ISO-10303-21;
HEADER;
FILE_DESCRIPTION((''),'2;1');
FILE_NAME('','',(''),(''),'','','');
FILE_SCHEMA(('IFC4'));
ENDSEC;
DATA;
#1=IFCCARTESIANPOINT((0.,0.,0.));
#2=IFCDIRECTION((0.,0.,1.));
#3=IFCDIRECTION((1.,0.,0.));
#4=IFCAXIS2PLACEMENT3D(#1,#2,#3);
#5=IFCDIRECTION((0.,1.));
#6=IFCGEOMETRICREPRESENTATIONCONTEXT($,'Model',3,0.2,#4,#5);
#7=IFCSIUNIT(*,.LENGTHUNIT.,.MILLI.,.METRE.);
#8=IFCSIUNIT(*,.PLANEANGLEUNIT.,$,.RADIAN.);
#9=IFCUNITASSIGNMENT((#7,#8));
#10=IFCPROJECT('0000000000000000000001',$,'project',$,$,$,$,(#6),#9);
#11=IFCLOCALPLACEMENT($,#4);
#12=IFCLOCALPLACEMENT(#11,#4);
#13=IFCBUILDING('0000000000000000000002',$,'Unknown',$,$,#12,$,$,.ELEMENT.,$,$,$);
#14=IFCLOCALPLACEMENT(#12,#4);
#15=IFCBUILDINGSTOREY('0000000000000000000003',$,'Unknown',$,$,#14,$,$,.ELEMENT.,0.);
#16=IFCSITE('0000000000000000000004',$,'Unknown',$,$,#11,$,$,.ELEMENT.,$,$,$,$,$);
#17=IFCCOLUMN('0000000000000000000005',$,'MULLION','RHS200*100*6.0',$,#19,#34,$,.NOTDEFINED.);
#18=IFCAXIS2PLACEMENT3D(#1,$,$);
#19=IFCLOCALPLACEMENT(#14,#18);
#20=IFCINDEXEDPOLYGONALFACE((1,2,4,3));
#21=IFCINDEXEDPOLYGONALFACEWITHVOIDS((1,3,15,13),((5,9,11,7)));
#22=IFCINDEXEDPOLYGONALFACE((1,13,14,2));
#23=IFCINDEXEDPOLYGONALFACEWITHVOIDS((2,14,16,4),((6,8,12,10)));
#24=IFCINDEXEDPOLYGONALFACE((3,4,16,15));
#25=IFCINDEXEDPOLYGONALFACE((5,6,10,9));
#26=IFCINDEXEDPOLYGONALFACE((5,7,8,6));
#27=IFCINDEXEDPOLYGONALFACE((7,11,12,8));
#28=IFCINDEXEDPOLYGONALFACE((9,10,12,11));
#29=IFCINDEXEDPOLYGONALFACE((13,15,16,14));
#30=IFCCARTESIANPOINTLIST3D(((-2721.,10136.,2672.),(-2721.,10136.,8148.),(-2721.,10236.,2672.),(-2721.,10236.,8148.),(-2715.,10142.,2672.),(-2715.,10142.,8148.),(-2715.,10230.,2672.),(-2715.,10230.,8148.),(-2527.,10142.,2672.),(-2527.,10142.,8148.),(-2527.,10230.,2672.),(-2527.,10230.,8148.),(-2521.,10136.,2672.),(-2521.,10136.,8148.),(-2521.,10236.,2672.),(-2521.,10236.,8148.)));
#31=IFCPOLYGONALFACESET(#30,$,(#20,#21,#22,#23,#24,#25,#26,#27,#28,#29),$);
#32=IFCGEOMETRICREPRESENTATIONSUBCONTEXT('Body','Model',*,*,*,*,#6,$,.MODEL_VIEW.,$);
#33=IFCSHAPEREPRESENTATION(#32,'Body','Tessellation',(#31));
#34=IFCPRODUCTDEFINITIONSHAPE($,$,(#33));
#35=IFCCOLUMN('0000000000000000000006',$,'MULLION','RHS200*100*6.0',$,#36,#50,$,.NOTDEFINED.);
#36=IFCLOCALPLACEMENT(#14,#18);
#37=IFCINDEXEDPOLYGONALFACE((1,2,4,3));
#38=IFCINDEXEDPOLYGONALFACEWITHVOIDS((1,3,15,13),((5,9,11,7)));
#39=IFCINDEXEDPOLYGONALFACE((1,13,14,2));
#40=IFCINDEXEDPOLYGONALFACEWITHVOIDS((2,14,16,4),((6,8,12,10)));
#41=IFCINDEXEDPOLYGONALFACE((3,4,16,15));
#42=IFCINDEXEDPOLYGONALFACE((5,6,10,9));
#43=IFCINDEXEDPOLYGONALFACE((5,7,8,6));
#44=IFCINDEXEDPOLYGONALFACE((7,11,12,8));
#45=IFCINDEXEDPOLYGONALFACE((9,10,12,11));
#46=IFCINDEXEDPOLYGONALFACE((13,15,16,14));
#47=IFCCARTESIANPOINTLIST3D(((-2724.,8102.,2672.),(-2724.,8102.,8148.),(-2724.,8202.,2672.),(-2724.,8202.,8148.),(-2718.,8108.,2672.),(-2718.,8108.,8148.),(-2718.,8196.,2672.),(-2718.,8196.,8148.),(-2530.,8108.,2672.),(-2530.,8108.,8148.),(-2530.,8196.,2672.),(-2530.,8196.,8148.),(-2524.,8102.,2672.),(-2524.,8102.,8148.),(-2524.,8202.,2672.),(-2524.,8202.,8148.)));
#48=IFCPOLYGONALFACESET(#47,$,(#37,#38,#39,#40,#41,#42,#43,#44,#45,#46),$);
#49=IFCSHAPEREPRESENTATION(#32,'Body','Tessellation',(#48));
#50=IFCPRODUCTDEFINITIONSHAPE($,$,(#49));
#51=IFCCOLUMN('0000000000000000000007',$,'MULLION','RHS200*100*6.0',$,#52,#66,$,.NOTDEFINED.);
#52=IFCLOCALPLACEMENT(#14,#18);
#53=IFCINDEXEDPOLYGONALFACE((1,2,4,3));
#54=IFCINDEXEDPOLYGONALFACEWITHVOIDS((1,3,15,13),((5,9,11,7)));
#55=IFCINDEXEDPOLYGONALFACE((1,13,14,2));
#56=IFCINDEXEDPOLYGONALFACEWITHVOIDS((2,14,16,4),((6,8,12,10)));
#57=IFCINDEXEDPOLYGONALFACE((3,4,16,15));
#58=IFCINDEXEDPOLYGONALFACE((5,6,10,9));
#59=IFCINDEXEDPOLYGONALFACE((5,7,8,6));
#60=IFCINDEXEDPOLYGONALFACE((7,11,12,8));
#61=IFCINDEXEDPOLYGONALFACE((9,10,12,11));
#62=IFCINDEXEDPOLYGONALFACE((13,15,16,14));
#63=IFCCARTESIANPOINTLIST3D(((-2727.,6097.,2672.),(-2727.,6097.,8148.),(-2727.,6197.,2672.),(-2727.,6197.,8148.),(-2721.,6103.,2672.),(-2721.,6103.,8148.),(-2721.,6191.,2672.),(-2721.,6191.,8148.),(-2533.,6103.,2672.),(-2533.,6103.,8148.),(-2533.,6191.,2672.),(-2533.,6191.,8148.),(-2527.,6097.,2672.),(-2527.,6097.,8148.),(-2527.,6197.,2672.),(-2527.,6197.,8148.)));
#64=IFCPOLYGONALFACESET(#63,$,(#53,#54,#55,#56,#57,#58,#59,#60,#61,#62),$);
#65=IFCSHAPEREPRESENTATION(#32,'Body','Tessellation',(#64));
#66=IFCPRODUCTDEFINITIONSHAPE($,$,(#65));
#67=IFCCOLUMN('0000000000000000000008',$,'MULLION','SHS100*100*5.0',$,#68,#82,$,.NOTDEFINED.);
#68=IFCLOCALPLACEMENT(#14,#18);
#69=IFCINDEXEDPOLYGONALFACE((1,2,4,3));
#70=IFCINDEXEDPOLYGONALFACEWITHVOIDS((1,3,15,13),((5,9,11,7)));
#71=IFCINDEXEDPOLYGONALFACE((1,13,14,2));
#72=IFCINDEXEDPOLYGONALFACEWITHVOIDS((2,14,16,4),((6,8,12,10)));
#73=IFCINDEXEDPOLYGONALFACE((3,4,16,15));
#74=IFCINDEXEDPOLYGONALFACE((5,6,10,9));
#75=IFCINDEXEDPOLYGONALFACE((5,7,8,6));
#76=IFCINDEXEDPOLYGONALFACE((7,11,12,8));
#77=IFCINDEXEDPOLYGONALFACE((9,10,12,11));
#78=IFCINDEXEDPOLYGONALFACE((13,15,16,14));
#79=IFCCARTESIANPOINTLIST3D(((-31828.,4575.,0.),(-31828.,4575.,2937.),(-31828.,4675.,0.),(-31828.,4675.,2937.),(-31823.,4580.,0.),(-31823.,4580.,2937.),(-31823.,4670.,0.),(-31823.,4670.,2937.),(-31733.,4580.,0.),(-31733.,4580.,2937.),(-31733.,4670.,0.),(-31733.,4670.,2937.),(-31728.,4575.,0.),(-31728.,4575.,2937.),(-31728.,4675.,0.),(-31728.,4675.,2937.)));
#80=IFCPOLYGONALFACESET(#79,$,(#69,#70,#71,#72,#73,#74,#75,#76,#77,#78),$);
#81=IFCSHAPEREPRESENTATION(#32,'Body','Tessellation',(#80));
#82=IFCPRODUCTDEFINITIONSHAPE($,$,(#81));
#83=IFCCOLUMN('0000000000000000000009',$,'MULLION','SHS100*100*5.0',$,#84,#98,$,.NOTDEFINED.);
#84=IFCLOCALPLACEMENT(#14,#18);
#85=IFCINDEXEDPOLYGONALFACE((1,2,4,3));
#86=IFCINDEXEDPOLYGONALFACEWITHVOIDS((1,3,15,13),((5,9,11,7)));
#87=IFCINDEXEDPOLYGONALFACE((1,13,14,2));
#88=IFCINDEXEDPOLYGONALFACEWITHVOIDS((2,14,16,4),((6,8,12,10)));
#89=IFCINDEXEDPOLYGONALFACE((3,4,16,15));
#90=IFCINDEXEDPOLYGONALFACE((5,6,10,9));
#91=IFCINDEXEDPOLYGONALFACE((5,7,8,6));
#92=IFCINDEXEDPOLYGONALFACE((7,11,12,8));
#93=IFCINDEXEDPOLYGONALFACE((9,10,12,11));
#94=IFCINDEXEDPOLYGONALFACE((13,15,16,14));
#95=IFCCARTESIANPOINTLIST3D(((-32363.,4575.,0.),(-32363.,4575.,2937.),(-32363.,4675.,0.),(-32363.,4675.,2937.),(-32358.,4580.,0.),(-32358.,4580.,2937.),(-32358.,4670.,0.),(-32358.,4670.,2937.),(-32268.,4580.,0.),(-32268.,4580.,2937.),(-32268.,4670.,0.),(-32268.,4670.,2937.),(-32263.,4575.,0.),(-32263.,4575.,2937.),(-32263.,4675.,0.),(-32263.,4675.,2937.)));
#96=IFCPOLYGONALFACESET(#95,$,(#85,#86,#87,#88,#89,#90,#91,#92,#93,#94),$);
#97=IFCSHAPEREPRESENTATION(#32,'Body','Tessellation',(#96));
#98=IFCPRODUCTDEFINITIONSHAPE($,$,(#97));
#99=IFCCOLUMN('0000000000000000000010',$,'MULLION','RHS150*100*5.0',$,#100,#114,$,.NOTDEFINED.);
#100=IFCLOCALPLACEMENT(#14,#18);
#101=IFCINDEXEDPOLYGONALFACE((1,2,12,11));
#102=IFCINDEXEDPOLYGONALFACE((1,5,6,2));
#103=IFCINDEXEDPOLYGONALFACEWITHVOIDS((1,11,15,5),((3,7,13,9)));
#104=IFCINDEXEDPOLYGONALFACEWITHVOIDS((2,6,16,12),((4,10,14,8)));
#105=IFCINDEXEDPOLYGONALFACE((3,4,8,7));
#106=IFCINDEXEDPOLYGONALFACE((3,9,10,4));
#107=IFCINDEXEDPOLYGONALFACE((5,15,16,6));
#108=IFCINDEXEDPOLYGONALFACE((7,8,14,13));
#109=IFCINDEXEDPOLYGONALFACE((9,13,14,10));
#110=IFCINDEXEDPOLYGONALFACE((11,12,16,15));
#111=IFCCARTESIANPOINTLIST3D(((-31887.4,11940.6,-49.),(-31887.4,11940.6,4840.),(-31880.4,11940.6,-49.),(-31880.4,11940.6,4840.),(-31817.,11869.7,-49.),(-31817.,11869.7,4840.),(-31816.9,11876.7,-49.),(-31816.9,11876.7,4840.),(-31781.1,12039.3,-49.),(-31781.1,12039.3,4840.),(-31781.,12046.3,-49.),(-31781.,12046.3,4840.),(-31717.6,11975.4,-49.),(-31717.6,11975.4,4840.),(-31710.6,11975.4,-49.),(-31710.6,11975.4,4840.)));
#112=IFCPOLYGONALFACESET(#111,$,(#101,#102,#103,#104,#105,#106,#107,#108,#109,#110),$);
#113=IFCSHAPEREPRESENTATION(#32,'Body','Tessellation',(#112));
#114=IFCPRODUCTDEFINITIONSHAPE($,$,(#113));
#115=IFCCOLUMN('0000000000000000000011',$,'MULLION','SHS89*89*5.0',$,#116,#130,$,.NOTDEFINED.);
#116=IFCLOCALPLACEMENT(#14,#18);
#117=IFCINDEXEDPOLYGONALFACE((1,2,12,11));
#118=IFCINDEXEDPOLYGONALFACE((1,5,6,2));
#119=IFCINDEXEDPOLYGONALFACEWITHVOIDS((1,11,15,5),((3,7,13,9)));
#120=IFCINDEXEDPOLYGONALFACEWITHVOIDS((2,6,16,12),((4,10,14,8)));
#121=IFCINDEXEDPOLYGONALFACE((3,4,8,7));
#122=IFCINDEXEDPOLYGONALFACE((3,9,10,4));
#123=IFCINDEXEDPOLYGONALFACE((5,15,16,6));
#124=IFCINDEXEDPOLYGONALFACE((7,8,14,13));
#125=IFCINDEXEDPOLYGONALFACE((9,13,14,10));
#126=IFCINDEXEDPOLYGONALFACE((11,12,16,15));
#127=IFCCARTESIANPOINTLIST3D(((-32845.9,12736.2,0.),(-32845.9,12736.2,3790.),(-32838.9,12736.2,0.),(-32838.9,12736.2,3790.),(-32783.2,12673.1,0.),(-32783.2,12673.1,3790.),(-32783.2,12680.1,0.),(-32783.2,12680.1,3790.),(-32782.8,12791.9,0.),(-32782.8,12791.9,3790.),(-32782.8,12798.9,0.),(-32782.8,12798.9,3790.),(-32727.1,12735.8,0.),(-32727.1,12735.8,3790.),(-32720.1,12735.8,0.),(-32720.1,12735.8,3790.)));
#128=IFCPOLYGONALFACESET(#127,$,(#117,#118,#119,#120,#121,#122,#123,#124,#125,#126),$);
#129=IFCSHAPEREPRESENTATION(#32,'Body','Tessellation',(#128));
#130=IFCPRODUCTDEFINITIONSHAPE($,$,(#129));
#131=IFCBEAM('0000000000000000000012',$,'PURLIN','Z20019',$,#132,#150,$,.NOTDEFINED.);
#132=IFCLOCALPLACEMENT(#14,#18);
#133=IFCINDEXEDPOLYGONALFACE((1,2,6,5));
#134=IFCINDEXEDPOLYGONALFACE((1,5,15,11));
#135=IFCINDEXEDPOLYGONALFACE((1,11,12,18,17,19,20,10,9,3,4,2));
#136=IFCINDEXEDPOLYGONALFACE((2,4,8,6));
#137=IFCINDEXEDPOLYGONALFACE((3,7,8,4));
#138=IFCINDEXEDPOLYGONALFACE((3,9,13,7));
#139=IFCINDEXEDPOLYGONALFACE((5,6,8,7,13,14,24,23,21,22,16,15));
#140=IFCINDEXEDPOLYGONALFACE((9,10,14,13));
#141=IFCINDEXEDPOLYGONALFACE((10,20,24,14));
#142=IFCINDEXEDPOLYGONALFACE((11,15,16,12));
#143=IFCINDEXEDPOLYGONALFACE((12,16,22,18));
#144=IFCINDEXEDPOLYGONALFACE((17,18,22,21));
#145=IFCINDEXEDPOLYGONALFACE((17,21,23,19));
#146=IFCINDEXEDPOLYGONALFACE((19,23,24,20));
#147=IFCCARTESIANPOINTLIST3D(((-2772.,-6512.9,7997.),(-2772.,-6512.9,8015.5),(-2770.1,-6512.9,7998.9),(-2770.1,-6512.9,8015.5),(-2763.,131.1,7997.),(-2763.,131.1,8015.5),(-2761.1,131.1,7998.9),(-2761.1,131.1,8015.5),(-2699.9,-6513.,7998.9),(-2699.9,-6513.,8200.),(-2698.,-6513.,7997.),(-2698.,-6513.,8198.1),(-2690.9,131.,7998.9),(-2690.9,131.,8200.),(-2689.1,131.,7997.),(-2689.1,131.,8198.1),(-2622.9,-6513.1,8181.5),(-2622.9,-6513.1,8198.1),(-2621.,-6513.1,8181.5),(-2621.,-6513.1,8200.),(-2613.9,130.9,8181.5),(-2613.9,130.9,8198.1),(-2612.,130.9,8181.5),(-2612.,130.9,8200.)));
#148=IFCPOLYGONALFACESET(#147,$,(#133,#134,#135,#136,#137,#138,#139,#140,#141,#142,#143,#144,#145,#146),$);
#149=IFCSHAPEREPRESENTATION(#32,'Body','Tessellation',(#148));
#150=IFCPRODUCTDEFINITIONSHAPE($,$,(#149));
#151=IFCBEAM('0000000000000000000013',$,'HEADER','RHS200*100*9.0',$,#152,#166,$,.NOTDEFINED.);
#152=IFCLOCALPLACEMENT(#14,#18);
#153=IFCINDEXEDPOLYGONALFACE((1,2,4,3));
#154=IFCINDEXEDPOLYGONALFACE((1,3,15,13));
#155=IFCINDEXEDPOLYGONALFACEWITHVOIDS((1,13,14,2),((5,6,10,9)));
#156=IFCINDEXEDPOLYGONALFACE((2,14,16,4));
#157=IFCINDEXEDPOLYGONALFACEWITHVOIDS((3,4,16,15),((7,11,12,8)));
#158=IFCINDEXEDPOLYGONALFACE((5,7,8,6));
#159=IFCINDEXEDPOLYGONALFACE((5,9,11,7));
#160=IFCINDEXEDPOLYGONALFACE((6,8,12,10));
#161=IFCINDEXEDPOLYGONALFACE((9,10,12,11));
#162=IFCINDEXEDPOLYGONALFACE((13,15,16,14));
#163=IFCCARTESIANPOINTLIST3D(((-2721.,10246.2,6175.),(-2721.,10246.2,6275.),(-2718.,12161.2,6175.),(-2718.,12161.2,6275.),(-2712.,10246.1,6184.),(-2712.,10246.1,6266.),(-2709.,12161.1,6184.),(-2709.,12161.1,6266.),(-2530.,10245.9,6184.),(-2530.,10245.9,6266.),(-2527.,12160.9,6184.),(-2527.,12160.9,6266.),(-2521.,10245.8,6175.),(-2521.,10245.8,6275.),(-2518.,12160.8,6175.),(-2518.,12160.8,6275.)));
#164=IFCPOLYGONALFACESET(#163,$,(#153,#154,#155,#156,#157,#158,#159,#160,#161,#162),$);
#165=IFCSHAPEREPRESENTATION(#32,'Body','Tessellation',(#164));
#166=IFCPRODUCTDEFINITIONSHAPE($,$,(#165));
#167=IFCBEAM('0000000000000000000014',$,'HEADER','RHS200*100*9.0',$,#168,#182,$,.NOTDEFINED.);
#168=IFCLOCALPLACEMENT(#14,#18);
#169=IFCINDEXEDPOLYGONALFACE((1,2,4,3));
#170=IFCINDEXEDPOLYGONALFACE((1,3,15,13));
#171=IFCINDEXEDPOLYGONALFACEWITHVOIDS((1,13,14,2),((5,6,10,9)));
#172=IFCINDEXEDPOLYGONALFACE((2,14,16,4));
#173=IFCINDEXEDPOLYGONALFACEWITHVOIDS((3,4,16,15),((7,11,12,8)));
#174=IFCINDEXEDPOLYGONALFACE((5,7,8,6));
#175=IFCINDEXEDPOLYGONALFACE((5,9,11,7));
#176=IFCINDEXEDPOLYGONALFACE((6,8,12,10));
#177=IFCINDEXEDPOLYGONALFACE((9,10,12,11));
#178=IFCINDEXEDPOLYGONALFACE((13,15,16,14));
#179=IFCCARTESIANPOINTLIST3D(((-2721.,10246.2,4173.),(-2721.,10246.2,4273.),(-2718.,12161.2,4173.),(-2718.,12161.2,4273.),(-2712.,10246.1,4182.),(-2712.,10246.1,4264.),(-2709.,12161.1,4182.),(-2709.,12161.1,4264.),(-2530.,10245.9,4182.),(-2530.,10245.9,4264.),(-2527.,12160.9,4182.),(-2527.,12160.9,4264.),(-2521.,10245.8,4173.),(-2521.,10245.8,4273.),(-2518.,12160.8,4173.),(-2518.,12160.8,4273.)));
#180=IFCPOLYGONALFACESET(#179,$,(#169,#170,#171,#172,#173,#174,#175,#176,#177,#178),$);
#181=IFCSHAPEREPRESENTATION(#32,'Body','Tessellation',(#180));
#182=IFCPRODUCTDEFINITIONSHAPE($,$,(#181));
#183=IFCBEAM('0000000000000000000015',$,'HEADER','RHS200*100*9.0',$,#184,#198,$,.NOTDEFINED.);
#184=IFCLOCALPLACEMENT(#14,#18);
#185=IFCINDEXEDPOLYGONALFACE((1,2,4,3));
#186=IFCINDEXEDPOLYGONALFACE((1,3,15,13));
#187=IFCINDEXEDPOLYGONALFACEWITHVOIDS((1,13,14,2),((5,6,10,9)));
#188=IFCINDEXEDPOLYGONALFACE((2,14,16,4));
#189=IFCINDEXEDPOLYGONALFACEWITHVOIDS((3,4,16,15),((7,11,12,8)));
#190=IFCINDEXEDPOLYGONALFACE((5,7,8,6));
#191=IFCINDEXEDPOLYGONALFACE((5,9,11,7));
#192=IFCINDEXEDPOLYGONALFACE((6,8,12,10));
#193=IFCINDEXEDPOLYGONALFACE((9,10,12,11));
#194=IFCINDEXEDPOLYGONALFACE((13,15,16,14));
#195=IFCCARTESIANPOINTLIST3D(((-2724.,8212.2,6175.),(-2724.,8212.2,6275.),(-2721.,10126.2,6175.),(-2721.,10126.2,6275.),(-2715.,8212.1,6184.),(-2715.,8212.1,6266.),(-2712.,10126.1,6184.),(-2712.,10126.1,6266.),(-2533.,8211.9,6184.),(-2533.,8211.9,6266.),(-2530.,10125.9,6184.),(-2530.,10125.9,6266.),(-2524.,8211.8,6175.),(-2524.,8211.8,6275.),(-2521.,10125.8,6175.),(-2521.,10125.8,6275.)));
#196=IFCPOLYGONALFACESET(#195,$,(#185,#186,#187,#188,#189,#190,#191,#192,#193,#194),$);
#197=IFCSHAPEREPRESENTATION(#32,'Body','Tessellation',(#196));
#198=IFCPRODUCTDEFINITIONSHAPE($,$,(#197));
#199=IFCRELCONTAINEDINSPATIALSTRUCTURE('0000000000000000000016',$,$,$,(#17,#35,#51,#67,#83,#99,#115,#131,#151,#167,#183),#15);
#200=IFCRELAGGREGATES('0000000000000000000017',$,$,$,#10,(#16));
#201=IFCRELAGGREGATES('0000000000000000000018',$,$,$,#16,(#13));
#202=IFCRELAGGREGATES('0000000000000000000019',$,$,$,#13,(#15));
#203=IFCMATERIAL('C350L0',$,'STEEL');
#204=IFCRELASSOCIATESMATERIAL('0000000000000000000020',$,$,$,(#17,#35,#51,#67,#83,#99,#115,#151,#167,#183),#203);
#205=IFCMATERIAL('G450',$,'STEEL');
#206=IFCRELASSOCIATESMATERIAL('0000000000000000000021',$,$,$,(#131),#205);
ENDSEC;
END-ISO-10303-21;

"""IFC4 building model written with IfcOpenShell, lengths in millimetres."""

from ifc_helpers import new_model, si_unit, direction, frame, origin_with_axes, place, context, subcontext, project, spatial, line, indexed_curve, outline, extrude, material, element, save


model = new_model("IFC4")

# Units and contexts
model_context = context("Model", 3, precision=0.2, world=origin_with_axes(), true_north=direction((0.0, 1.0)))
body_context = subcontext(model_context, "Body", "Model", "MODEL_VIEW")
ifc_project = project(units=[si_unit("LENGTHUNIT", "METRE", prefix="MILLI"), si_unit("PLANEANGLEUNIT", "RADIAN")], contexts=[model_context])

# Site, building, storey
site_placement = place(None, origin_with_axes())
site = spatial("IfcSite", under=ifc_project, at=site_placement, Name="Unknown", CompositionType="ELEMENT")
building_placement = place(site_placement, origin_with_axes())
building = spatial("IfcBuilding", under=site, at=building_placement, Name="Unknown", CompositionType="ELEMENT")
storey_placement = place(building_placement, origin_with_axes())
storey = spatial("IfcBuildingStorey", under=building, at=storey_placement, Name="Unknown", CompositionType="ELEMENT", Elevation=0.0)

# Columns
ifc_material_1 = material(Name="C350L0", Category="STEEL")
for number, where, z_axis, x_axis, name in (
    (1, (-2621.0, 10186.0, 2672.0), (0.000017, -1.0, 0.0), (0.0, 0.0, 1.0), "MULLION"),
    (2, (-2624.0, 8152.0, 2672.0), (0.000017, -1.0, 0.0), (0.0, 0.0, 1.0), "MULLION"),
    (3, (-2627.0, 6147.0, 2672.0), (0.000017, -1.0, 0.0), (0.0, 0.0, 1.0), "MULLION"),
):
    element("IfcColumn", number, at=place(storey_placement, frame(where, z_axis=z_axis, x_axis=x_axis)), inside=storey, material=ifc_material_1, Name=name, Description="RHS200*100*6.0", PredefinedType="NOTDEFINED", context=body_context, shape_type="SolidModel", body=[
        extrude(outline(indexed_curve([(-50.0, -100.0), (50.0, -100.0), (50.0, 100.0), (-50.0, 100.0)], segments=[line(1, 2, 3, 4, 1)]), holes=[indexed_curve([(-44.0, -94.0), (-44.0, 94.0), (44.0, 94.0), (44.0, -94.0)], segments=[line(1, 2, 3, 4, 1)])]), frame((0.0, 0.0, 0.0), z_axis=(-1.0, 0.0, 0.0), x_axis=(0.0, 0.0, 1.0)), (0.0, 0.0, -1.0), 5476.0),
    ])
for number, where, z_axis, x_axis, name in (
    (4, (-31778.0, 4625.0, 0.0), (0.000017, -1.0, 0.0), (0.0, 0.0, 1.0), "MULLION"),
    (5, (-32313.0, 4625.0, 0.0), (0.000017, -1.0, 0.0), (0.0, 0.0, 1.0), "MULLION"),
):
    element("IfcColumn", number, at=place(storey_placement, frame(where, z_axis=z_axis, x_axis=x_axis)), inside=storey, material=ifc_material_1, Name=name, Description="SHS100*100*5.0", PredefinedType="NOTDEFINED", context=body_context, shape_type="SolidModel", body=[
        extrude(outline(indexed_curve([(-50.0, -50.0), (50.0, -50.0), (50.0, 50.0), (-50.0, 50.0)], segments=[line(1, 2, 3, 4, 1)]), holes=[indexed_curve([(-45.0, -45.0), (-45.0, 45.0), (45.0, 45.0), (45.0, -45.0)], segments=[line(1, 2, 3, 4, 1)])]), frame((0.0, 0.0, 0.0), z_axis=(-1.0, 0.0, 0.0), x_axis=(0.0, 0.0, 1.0)), (0.0, 0.0, -1.0), 2937.0),
    ])
column_1_placement = place(storey_placement, frame((-31799.0, 11958.0, -49.0), z_axis=(0.704882, -0.709325, 0.0), x_axis=(0.0, 0.0, 1.0)))
element("IfcColumn", 6, at=column_1_placement, inside=storey, material=ifc_material_1, Name="MULLION", Description="RHS150*100*5.0", PredefinedType="NOTDEFINED", context=body_context, shape_type="SolidModel", body=[
    extrude(outline(indexed_curve([(-50.0, -75.0), (50.0, -75.0), (50.0, 75.0), (-50.0, 75.0)], segments=[line(1, 2, 3, 4, 1)]), holes=[indexed_curve([(-45.0, -70.0), (-45.0, 70.0), (45.0, 70.0), (45.0, -70.0)], segments=[line(1, 2, 3, 4, 1)])]), frame((0.0, 0.0, 0.0), z_axis=(-1.0, 0.0, 0.0), x_axis=(0.0, 0.0, 1.0)), (0.0, 0.0, -1.0), 4889.0),
])
column_2_placement = place(storey_placement, frame((-32783.0, 12736.0, 0.0), z_axis=(0.709325, 0.704882, 0.0), x_axis=(0.0, 0.0, 1.0)))
element("IfcColumn", 7, at=column_2_placement, inside=storey, material=ifc_material_1, Name="MULLION", Description="SHS89*89*5.0", PredefinedType="NOTDEFINED", context=body_context, shape_type="SolidModel", body=[
    extrude(outline(indexed_curve([(-44.5, -44.5), (44.5, -44.5), (44.5, 44.5), (-44.5, 44.5)], segments=[line(1, 2, 3, 4, 1)]), holes=[indexed_curve([(-39.5, -39.5), (-39.5, 39.5), (39.5, 39.5), (39.5, -39.5)], segments=[line(1, 2, 3, 4, 1)])]), frame((0.0, 0.0, 0.0), z_axis=(-1.0, 0.0, 0.0), x_axis=(0.0, 0.0, 1.0)), (0.0, 0.0, -1.0), 3790.0),
])

# Beams
ifc_material_2 = material(Name="G450", Category="STEEL")
beam_1_placement = place(storey_placement, frame((-2690.0, 131.0, 8098.5), z_axis=(-0.999999, 0.001355, 0.0), x_axis=(-0.001355, -0.999999, 0.0)))
element("IfcBeam", 8, at=beam_1_placement, inside=storey, material=ifc_material_2, Name="PURLIN", Description="Z20019", PredefinedType="NOTDEFINED", context=body_context, shape_type="SolidModel", body=[
    extrude(outline(indexed_curve([(73.0, -101.5), (73.0, -83.0), (71.2, -83.0), (71.2, -99.6), (0.9, -99.6), (0.9, 101.5), (-78.0, 101.5), (-78.0, 83.0), (-76.2, 83.0), (-76.2, 99.6), (-0.9, 99.6), (-0.9, -101.5)], segments=[line(1, 2, 3, 4, 5, 6, 7, 8, 9, 10, 11, 12, 1)])), frame((0.0, 0.0, 0.0), z_axis=(-1.0, 0.0, 0.0), x_axis=(0.0, 0.0, 1.0)), (0.0, 0.0, -1.0), 6644.0),
])
for number, where, z_axis, x_axis, name in (
    (9, (-2621.0, 10246.0, 6225.0), (0.0, 0.0, 1.0), (0.001567, 0.999999, 0.0), "HEADER"),
    (10, (-2621.0, 10246.0, 4223.0), (0.0, 0.0, 1.0), (0.001567, 0.999999, 0.0), "HEADER"),
):
    element("IfcBeam", number, at=place(storey_placement, frame(where, z_axis=z_axis, x_axis=x_axis)), inside=storey, material=ifc_material_1, Name=name, Description="RHS200*100*9.0", PredefinedType="NOTDEFINED", context=body_context, shape_type="SolidModel", body=[
        extrude(outline(indexed_curve([(-50.0, -100.0), (50.0, -100.0), (50.0, 100.0), (-50.0, 100.0)], segments=[line(1, 2, 3, 4, 1)]), holes=[indexed_curve([(-41.0, -91.0), (-41.0, 91.0), (41.0, 91.0), (41.0, -91.0)], segments=[line(1, 2, 3, 4, 1)])]), frame((0.0, 0.0, 0.0), z_axis=(-1.0, 0.0, 0.0), x_axis=(0.0, 0.0, 1.0)), (0.0, 0.0, -1.0), 1915.0),
    ])
for number, where, z_axis, x_axis, name in (
    (11, (-2624.0, 8212.0, 6225.0), (0.0, 0.0, 1.0), (0.001567, 0.999999, 0.0), "HEADER"),
):
    element("IfcBeam", number, at=place(storey_placement, frame(where, z_axis=z_axis, x_axis=x_axis)), inside=storey, material=ifc_material_1, Name=name, Description="RHS200*100*9.0", PredefinedType="NOTDEFINED", context=body_context, shape_type="SolidModel", body=[
        extrude(outline(indexed_curve([(-50.0, -100.0), (50.0, -100.0), (50.0, 100.0), (-50.0, 100.0)], segments=[line(1, 2, 3, 4, 1)]), holes=[indexed_curve([(-41.0, -91.0), (-41.0, 91.0), (41.0, 91.0), (41.0, -91.0)], segments=[line(1, 2, 3, 4, 1)])]), frame((0.0, 0.0, 0.0), z_axis=(-1.0, 0.0, 0.0), x_axis=(0.0, 0.0, 1.0)), (0.0, 0.0, -1.0), 1914.0),
    ])

save(model, "model.ifc")
